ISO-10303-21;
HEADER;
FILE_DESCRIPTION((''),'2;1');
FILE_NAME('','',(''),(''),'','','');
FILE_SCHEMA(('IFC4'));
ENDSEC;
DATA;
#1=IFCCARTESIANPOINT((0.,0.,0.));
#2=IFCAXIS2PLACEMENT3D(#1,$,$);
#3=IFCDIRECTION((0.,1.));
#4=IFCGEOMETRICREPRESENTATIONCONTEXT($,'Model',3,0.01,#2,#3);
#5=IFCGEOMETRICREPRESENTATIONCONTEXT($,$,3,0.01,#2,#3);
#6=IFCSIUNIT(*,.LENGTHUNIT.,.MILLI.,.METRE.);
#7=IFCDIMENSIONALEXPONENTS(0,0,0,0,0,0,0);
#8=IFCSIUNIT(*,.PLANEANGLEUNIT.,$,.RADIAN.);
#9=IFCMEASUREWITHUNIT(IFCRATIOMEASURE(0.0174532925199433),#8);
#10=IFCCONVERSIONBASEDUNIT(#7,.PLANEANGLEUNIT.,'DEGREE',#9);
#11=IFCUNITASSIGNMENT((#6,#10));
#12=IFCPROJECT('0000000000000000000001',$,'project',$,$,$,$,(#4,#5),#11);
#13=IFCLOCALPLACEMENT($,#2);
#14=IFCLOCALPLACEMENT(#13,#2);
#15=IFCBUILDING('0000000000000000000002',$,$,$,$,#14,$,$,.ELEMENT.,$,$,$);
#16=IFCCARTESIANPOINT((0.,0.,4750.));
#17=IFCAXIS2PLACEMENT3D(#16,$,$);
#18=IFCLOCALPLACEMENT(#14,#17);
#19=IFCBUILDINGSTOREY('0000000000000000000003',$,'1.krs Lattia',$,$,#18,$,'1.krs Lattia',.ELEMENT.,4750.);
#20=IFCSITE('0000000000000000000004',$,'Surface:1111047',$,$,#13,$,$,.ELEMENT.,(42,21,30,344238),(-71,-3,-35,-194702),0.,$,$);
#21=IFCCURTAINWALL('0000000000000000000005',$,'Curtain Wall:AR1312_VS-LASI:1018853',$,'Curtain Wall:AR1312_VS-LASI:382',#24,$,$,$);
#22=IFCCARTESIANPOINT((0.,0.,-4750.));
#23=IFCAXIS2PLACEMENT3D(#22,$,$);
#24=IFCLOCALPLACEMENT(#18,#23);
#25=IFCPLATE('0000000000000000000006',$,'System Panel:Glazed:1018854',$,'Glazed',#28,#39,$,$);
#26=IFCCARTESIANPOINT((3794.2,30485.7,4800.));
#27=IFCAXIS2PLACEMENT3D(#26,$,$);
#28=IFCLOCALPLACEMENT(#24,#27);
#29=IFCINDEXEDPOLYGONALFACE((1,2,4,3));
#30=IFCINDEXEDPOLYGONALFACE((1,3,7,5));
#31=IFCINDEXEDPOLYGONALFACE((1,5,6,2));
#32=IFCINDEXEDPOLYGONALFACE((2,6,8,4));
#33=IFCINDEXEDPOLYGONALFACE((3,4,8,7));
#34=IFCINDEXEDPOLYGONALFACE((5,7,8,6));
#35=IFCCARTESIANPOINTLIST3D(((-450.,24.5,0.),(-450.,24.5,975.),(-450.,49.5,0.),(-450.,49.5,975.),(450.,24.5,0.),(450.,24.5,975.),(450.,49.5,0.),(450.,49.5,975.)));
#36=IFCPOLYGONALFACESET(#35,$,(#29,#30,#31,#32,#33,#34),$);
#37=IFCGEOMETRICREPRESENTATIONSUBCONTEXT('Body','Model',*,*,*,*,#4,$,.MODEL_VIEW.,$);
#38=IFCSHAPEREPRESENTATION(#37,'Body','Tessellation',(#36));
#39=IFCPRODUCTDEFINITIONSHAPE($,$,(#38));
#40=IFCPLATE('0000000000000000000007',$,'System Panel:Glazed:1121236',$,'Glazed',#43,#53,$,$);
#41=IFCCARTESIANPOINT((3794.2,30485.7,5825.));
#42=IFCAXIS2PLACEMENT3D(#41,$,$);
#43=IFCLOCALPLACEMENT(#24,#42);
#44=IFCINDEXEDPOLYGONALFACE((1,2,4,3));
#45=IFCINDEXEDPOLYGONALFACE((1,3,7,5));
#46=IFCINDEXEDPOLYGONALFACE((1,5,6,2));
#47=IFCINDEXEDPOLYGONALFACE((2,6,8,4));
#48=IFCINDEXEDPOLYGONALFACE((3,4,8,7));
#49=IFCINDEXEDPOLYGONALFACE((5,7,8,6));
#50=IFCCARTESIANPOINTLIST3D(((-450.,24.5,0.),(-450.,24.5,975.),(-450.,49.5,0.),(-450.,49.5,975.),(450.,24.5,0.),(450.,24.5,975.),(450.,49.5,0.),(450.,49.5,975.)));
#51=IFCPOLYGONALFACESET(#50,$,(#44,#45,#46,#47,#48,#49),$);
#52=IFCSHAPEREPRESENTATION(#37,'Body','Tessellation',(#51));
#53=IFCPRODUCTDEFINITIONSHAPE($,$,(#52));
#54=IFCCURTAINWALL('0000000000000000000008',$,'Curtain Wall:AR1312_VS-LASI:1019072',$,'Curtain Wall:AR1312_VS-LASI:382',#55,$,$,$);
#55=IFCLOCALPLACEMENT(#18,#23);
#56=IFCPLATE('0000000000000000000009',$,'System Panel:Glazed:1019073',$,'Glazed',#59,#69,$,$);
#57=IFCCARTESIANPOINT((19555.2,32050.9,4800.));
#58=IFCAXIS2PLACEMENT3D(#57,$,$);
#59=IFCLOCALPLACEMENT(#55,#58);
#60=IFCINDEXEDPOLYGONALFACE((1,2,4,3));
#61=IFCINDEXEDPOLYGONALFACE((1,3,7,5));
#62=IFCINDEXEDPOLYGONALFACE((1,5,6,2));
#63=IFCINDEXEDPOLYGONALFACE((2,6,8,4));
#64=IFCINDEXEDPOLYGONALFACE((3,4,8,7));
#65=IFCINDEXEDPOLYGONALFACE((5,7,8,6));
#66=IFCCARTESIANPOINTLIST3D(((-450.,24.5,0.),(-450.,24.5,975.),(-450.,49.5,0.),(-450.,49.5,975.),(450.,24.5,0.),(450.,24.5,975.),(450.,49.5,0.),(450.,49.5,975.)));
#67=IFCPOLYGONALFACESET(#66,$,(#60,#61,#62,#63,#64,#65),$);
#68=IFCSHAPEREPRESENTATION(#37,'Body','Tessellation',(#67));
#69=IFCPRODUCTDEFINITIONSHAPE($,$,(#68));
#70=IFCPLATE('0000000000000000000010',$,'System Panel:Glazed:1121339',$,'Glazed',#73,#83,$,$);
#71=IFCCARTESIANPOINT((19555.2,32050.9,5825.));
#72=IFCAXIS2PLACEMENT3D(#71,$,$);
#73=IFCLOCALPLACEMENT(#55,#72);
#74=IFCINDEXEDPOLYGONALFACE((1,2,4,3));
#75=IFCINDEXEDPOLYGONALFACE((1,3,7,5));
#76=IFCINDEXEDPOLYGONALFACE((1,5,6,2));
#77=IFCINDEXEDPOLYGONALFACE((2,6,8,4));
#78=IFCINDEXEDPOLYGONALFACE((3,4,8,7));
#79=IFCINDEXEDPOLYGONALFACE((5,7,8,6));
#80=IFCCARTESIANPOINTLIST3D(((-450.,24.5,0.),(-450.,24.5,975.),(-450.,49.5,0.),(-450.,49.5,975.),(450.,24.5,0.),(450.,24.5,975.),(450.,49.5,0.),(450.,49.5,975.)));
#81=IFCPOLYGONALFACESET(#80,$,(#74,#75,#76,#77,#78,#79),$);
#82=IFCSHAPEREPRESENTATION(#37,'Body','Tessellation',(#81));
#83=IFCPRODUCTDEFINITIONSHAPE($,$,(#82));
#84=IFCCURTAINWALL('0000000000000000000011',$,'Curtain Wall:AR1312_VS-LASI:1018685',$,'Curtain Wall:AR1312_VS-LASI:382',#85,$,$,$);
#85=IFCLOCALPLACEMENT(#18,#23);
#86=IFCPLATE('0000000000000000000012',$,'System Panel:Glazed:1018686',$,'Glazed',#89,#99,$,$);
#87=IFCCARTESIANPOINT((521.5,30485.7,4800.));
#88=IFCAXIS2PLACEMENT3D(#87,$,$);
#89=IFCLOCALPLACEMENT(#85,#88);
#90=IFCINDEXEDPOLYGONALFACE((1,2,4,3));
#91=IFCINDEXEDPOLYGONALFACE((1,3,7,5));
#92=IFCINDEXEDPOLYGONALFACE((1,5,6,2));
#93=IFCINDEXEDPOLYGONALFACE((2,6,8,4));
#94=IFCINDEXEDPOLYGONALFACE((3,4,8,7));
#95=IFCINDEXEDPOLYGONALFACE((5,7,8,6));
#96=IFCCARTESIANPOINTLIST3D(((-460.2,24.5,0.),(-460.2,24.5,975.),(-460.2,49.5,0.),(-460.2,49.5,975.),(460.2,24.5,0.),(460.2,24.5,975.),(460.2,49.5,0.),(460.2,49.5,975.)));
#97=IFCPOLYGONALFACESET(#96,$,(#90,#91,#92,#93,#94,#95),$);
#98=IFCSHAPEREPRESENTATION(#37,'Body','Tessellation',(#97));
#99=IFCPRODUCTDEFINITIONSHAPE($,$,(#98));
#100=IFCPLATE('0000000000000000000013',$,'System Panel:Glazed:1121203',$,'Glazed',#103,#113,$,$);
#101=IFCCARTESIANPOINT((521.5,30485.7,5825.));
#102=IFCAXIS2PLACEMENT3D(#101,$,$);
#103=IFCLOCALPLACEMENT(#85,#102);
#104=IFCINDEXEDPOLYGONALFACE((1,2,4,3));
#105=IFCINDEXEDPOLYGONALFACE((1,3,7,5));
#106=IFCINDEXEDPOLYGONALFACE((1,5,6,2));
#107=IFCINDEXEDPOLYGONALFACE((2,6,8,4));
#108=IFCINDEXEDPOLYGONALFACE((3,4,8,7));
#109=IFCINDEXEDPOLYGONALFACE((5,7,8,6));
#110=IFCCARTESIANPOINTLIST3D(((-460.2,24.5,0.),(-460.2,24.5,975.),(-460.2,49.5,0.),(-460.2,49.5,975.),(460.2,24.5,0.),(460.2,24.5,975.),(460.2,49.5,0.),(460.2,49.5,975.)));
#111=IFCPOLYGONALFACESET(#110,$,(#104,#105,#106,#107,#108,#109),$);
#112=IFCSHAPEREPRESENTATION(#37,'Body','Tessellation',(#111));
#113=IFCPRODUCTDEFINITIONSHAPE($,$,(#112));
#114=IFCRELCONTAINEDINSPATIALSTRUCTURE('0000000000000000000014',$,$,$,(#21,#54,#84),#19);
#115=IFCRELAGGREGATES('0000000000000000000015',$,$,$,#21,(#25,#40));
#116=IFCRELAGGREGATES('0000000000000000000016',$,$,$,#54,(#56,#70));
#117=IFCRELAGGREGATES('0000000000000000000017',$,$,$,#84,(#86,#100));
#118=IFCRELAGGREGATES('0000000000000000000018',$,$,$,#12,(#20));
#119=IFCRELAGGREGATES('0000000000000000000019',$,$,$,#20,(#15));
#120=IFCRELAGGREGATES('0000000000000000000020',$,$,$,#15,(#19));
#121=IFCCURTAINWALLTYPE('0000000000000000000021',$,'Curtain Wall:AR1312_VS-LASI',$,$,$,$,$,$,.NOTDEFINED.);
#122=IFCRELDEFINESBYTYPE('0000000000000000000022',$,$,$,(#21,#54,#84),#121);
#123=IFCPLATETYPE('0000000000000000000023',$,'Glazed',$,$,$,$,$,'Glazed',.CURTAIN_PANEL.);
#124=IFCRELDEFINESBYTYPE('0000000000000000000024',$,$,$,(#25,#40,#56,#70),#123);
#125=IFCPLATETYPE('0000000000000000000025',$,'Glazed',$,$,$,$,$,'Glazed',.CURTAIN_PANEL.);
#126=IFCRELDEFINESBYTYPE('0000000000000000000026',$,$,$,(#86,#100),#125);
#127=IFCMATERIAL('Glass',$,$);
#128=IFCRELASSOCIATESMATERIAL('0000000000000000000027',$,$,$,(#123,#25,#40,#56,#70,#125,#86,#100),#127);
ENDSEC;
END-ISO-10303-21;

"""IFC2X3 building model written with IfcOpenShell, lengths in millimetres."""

from ifc_helpers import new_model, entity, si_unit, converted_unit, direction, frame, origin, origin_2d_with_axis, place, context, subcontext, project, spatial, rectangle, extrude, source, transform, mapped, material, type_object, type_shapes, element, aggregate, save


model = new_model("IFC2X3")

# Units and contexts
model_context = context("Model", 3, precision=0.01, world=origin(), true_north=direction((0.0, 1.0)))
context_of_model = context(None, 3, precision=0.01, world=origin(), true_north=direction((0.0, 1.0)))
body_context = subcontext(model_context, "Body", "Model", "MODEL_VIEW")
ifc_project = project(units=[si_unit("LENGTHUNIT", "METRE", prefix="MILLI"), converted_unit("PLANEANGLEUNIT", "DEGREE", entity("IfcRatioMeasure", 0.0174532925199433), si_unit("PLANEANGLEUNIT", "RADIAN"), dimensions=[0, 0, 0, 0, 0, 0, 0])], contexts=[model_context, context_of_model])

# Site, building, storey
site_placement = place(None, origin())
site = spatial("IfcSite", under=ifc_project, at=site_placement, Name="Surface:1111047", CompositionType="ELEMENT", RefLatitude=(42, 21, 30, 344238), RefLongitude=(-71, -3, -35, -194702), RefElevation=0.0)
building_placement = place(site_placement, origin())
building = spatial("IfcBuilding", under=site, at=building_placement, CompositionType="ELEMENT")
storey_placement = place(building_placement, frame((0.0, 0.0, 4750.0)))
storey = spatial("IfcBuildingStorey", under=building, at=storey_placement, Name="1.krs Lattia", LongName="1.krs Lattia", CompositionType="ELEMENT", Elevation=4750.0)

# Shared definitions
curtain_wall_type = type_object("IfcCurtainWallType", Name="Curtain Wall:AR1312_VS-LASI", PredefinedType="NOTDEFINED")

# Curtain walls, plates
curtain_wall_1_placement = place(storey_placement, frame((0.0, 0.0, -4750.0)))
curtain_wall_1 = element("IfcCurtainWall", 1, at=curtain_wall_1_placement, inside=storey, type_object=curtain_wall_type, Name="Curtain Wall:AR1312_VS-LASI:1018853", ObjectType="Curtain Wall:AR1312_VS-LASI:382")
ifc_material_1 = material(Name="Glass")
plate_type_1 = type_object("IfcPlateType", Name="Glazed", ElementType="Glazed", PredefinedType="CURTAIN_PANEL", material=ifc_material_1)
shared_shape_1 = source(origin(), body_context, "Body", "SweptSolid", [
    extrude(rectangle(XDim=25.0, YDim=900.0, at=origin_2d_with_axis()), frame((0.0, 37.0, 0.0), z_axis=(0.0, 0.0, 1.0), x_axis=(0.0, 1.0, 0.0)), (0.0, 0.0, 1.0), 975.0),
])
type_shapes(plate_type_1, [shared_shape_1])
plate_1_placement = place(curtain_wall_1_placement, frame((3794.2, 30485.7, 4800.0)))
plate_1 = element("IfcPlate", 2, at=plate_1_placement, type_object=plate_type_1, material=ifc_material_1, Name="System Panel:Glazed:1018854", ObjectType="Glazed", context=body_context, shape_type="MappedRepresentation", body=[
    mapped(shared_shape_1, transform((0.0, 0.0, 0.0), scale=1.0)),
])
plate_2_placement = place(curtain_wall_1_placement, frame((3794.2, 30485.7, 5825.0)))
plate_2 = element("IfcPlate", 3, at=plate_2_placement, type_object=plate_type_1, material=ifc_material_1, Name="System Panel:Glazed:1121236", ObjectType="Glazed", context=body_context, shape_type="MappedRepresentation", body=[
    mapped(shared_shape_1, transform((0.0, 0.0, 0.0), scale=1.0)),
])
aggregate(curtain_wall_1, [plate_1, plate_2])
curtain_wall_2_placement = place(storey_placement, frame((0.0, 0.0, -4750.0)))
curtain_wall_2 = element("IfcCurtainWall", 4, at=curtain_wall_2_placement, inside=storey, type_object=curtain_wall_type, Name="Curtain Wall:AR1312_VS-LASI:1019072", ObjectType="Curtain Wall:AR1312_VS-LASI:382")
plate_3_placement = place(curtain_wall_2_placement, frame((19555.2, 32050.9, 4800.0)))
plate_3 = element("IfcPlate", 5, at=plate_3_placement, type_object=plate_type_1, material=ifc_material_1, Name="System Panel:Glazed:1019073", ObjectType="Glazed", context=body_context, shape_type="MappedRepresentation", body=[
    mapped(shared_shape_1, transform((0.0, 0.0, 0.0), scale=1.0)),
])
plate_4_placement = place(curtain_wall_2_placement, frame((19555.2, 32050.9, 5825.0)))
plate_4 = element("IfcPlate", 6, at=plate_4_placement, type_object=plate_type_1, material=ifc_material_1, Name="System Panel:Glazed:1121339", ObjectType="Glazed", context=body_context, shape_type="MappedRepresentation", body=[
    mapped(shared_shape_1, transform((0.0, 0.0, 0.0), scale=1.0)),
])
aggregate(curtain_wall_2, [plate_3, plate_4])
curtain_wall_3_placement = place(storey_placement, frame((0.0, 0.0, -4750.0)))
curtain_wall_3 = element("IfcCurtainWall", 7, at=curtain_wall_3_placement, inside=storey, type_object=curtain_wall_type, Name="Curtain Wall:AR1312_VS-LASI:1018685", ObjectType="Curtain Wall:AR1312_VS-LASI:382")
plate_type_2 = type_object("IfcPlateType", Name="Glazed", ElementType="Glazed", PredefinedType="CURTAIN_PANEL", material=ifc_material_1)
shared_shape_2 = source(origin(), body_context, "Body", "SweptSolid", [
    extrude(rectangle(XDim=25.0, YDim=920.4, at=origin_2d_with_axis()), frame((0.0, 37.0, 0.0), z_axis=(0.0, 0.0, 1.0), x_axis=(0.0, 1.0, 0.0)), (0.0, 0.0, 1.0), 975.0),
])
type_shapes(plate_type_2, [shared_shape_2])
plate_5_placement = place(curtain_wall_3_placement, frame((521.5, 30485.7, 4800.0)))
plate_5 = element("IfcPlate", 8, at=plate_5_placement, type_object=plate_type_2, material=ifc_material_1, Name="System Panel:Glazed:1018686", ObjectType="Glazed", context=body_context, shape_type="MappedRepresentation", body=[
    mapped(shared_shape_2, transform((0.0, 0.0, 0.0), scale=1.0)),
])
plate_6_placement = place(curtain_wall_3_placement, frame((521.5, 30485.7, 5825.0)))
plate_6 = element("IfcPlate", 9, at=plate_6_placement, type_object=plate_type_2, material=ifc_material_1, Name="System Panel:Glazed:1121203", ObjectType="Glazed", context=body_context, shape_type="MappedRepresentation", body=[
    mapped(shared_shape_2, transform((0.0, 0.0, 0.0), scale=1.0)),
])
aggregate(curtain_wall_3, [plate_5, plate_6])

save(model, "model.ifc")
